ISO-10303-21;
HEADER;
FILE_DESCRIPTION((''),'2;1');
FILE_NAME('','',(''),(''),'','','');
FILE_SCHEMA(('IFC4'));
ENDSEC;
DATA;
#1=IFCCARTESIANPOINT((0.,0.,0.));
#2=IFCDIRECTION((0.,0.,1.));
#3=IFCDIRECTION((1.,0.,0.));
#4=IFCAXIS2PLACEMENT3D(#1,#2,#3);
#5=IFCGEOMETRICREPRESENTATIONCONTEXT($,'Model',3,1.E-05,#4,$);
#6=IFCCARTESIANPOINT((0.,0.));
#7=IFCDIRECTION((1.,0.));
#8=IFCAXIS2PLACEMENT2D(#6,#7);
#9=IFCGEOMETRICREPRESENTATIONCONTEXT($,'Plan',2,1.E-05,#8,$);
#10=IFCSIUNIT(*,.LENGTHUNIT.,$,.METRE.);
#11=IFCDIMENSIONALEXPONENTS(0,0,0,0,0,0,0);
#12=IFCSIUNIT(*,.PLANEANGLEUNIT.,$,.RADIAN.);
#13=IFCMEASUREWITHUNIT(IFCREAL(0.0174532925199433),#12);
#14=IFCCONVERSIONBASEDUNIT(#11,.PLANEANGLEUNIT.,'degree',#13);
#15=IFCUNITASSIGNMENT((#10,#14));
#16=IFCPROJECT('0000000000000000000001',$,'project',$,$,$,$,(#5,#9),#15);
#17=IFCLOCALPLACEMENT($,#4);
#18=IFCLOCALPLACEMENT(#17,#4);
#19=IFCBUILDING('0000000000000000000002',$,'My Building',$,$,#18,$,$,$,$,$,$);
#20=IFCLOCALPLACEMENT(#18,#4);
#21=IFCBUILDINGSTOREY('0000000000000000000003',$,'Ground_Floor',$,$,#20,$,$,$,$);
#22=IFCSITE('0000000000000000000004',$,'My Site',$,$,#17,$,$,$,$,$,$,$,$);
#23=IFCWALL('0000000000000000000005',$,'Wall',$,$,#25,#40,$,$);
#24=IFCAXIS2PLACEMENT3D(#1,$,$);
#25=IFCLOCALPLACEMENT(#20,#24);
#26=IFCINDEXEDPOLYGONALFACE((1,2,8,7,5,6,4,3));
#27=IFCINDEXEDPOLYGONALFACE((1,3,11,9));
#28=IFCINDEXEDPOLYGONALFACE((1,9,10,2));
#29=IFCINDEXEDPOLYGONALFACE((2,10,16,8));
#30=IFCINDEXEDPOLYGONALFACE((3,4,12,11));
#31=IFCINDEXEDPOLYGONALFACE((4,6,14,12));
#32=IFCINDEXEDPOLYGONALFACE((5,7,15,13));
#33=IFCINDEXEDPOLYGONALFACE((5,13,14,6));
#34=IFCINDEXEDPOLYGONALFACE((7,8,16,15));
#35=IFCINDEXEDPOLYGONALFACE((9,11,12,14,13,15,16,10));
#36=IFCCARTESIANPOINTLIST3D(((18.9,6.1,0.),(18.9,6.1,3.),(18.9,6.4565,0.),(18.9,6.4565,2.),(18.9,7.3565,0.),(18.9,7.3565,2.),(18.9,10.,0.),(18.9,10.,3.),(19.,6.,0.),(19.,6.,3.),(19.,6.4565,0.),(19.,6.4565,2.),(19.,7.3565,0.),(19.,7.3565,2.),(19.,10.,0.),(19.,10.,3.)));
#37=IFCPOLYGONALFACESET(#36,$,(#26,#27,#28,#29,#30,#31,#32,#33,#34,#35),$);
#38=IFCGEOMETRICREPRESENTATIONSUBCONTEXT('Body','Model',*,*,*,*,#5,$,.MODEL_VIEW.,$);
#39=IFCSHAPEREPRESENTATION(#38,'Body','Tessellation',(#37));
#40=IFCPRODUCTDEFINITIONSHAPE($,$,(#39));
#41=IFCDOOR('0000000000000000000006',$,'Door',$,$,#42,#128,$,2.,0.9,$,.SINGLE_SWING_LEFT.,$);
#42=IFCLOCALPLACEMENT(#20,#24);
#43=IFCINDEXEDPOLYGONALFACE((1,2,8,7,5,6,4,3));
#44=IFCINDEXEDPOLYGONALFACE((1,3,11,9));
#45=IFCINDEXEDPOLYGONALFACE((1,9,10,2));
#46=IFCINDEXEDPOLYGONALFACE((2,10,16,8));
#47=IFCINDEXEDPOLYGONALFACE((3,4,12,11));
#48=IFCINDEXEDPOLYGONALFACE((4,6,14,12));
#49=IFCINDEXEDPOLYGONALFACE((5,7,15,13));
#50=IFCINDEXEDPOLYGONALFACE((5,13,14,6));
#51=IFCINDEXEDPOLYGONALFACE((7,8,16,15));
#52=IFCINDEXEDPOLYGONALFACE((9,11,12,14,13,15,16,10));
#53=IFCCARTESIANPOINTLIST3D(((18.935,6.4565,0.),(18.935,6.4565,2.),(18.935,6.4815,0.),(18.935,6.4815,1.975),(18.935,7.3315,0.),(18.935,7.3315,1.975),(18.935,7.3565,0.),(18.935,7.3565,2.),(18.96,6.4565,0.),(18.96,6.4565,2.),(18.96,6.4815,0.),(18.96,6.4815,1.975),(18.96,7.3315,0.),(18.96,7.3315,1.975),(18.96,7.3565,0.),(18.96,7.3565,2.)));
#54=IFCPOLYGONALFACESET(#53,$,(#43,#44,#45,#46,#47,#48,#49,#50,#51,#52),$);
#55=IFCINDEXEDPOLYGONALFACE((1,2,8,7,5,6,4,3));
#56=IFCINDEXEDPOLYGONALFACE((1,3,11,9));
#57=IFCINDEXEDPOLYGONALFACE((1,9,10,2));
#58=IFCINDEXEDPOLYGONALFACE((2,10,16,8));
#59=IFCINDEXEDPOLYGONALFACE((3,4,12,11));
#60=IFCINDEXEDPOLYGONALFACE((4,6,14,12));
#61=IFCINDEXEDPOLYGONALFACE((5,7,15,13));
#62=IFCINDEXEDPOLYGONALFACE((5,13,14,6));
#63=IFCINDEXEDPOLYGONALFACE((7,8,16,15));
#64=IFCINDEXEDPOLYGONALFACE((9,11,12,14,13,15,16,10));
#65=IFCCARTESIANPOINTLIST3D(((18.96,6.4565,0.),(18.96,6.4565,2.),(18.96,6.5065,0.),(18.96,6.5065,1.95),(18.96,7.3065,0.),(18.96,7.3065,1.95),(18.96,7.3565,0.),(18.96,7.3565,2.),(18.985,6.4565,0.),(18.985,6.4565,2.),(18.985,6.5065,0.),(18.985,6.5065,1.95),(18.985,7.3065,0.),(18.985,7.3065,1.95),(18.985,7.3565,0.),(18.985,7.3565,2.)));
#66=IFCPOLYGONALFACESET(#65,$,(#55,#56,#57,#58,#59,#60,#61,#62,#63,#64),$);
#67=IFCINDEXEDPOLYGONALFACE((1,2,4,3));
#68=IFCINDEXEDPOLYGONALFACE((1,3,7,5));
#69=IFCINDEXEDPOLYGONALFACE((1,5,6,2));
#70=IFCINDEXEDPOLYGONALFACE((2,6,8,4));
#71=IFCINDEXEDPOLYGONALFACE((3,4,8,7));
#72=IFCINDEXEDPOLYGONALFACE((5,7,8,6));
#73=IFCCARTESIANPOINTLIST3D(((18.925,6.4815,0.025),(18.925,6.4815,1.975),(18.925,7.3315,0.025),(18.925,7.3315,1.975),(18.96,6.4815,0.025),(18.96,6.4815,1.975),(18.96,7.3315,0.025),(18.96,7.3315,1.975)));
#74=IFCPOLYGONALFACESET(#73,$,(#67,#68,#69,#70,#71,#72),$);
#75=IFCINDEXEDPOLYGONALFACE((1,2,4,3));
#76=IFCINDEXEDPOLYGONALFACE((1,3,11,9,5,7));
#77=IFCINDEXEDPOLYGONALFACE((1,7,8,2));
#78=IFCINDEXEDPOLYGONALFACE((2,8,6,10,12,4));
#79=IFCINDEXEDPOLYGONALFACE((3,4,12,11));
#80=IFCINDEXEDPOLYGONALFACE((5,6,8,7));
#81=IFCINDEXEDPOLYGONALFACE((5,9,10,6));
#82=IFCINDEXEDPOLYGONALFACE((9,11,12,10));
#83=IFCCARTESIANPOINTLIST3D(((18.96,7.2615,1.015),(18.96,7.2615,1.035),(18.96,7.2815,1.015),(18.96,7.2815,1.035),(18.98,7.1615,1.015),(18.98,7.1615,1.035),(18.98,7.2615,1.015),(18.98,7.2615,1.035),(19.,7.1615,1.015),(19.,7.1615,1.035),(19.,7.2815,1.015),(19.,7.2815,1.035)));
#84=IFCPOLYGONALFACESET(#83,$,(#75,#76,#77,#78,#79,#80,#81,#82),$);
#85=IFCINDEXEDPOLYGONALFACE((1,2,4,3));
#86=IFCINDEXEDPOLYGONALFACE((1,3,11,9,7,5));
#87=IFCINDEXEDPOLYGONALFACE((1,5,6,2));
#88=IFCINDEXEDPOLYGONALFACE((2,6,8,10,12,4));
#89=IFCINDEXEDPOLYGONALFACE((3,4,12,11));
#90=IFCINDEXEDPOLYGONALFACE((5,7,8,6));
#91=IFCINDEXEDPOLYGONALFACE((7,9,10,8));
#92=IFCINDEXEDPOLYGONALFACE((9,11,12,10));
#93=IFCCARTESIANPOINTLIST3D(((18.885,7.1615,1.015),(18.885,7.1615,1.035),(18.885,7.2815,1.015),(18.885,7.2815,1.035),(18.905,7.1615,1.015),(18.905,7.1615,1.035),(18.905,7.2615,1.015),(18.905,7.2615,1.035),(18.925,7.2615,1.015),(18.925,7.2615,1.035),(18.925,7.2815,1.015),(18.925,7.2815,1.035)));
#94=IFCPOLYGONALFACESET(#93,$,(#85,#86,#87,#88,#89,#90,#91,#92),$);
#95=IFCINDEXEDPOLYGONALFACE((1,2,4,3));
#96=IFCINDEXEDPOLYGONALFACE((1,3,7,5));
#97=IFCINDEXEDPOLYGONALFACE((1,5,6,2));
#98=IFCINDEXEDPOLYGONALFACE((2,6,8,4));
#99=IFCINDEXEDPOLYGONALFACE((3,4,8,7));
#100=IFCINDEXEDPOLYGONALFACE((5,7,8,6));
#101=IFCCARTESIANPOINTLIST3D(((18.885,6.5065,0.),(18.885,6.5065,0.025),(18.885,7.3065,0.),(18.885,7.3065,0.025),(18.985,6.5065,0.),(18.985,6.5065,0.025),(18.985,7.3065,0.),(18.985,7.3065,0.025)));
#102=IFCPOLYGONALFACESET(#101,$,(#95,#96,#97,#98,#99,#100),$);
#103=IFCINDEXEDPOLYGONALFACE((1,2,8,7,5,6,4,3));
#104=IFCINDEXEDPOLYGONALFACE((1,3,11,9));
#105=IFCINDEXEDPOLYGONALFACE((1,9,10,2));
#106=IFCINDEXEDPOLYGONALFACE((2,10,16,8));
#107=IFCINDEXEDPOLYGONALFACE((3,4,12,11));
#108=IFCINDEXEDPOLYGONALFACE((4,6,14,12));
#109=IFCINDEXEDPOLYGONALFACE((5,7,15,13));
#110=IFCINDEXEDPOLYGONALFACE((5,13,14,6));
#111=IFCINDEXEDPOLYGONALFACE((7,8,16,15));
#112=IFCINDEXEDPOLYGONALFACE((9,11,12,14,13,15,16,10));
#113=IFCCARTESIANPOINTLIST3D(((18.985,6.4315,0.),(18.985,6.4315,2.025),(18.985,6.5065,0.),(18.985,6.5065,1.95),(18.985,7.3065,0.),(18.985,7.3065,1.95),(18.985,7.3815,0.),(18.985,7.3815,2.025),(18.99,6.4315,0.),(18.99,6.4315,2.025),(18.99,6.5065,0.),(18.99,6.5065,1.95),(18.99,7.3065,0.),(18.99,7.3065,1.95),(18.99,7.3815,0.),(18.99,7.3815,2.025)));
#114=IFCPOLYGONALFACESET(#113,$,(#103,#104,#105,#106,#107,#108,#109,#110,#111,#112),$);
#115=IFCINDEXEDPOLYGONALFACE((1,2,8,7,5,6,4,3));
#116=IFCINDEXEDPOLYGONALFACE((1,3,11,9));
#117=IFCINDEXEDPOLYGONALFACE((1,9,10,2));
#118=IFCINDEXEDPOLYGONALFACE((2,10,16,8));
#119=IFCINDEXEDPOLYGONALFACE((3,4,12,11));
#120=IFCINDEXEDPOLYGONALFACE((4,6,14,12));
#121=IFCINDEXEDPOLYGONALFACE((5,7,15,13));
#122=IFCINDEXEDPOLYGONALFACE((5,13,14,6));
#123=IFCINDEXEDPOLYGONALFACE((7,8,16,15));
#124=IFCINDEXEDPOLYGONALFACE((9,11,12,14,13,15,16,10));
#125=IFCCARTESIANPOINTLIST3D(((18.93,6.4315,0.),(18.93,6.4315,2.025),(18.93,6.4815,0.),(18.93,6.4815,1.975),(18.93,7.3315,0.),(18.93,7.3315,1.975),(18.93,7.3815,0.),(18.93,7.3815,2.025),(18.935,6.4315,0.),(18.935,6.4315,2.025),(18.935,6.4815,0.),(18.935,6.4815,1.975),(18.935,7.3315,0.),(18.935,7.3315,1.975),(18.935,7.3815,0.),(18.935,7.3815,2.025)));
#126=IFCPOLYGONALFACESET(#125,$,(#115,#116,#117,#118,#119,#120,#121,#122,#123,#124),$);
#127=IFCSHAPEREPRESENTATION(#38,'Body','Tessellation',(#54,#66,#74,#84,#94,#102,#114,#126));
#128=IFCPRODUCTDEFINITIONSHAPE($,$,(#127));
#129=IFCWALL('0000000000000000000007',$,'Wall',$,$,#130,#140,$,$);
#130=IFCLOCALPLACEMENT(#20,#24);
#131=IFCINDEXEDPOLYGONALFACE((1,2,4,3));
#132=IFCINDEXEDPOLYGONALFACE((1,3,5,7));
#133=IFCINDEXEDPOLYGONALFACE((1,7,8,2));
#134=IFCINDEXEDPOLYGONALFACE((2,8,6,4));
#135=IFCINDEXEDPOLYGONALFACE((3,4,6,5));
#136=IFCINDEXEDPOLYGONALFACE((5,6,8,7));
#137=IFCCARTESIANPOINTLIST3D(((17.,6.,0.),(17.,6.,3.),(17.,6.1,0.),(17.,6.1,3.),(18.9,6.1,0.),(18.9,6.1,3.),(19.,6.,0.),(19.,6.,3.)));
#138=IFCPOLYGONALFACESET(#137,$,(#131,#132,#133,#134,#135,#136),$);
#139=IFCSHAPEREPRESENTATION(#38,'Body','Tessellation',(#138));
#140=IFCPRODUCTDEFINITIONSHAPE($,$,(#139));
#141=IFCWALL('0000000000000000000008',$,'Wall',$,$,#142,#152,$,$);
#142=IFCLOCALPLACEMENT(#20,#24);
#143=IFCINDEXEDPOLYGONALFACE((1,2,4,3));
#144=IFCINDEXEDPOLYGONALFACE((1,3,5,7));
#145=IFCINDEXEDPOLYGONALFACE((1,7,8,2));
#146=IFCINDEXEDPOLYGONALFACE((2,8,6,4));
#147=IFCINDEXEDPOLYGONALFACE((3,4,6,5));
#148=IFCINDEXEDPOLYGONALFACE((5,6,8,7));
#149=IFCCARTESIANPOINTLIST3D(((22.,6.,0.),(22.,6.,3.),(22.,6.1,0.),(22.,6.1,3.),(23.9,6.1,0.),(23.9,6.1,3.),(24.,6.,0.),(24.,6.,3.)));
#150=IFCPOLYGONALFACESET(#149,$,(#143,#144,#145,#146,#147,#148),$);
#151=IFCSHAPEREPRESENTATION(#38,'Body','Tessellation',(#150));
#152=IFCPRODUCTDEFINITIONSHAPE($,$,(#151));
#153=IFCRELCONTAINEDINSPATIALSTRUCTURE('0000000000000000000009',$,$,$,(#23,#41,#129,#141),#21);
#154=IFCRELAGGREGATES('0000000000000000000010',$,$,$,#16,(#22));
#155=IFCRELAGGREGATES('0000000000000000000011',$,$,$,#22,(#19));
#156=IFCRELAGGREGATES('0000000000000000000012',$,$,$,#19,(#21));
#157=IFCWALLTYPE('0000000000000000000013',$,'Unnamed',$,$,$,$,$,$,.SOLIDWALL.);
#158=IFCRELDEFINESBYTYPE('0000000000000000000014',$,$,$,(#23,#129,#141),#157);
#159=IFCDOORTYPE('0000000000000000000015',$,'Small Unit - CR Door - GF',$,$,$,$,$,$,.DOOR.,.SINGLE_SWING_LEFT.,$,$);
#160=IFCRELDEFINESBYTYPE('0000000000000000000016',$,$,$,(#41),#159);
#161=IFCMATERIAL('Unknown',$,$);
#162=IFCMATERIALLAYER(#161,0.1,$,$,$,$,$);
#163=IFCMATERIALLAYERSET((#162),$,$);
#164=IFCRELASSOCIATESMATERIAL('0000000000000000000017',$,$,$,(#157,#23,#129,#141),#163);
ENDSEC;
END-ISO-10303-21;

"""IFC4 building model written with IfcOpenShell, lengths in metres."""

from ifc_helpers import new_model, entity, si_unit, converted_unit, frame, origin_with_axes, origin_2d_with_axis, place, context, subcontext, project, spatial, line, indexed_curve, outline, extrude, shape, source, transform, mapped, material, layer, layer_set, layer_usage, type_object, type_shapes, element, fill, save


model = new_model("IFC4")

# Units and contexts
model_context = context("Model", 3, precision=1e-05, world=origin_with_axes())
plan_context = context("Plan", 2, precision=1e-05, world=origin_2d_with_axis())
body_context_1 = subcontext(model_context, "Body", "Model", "MODEL_VIEW")
body_context_2 = subcontext(plan_context, "Body", "Plan", "PLAN_VIEW")
ifc_project = project(units=[si_unit("LENGTHUNIT", "METRE"), converted_unit("PLANEANGLEUNIT", "degree", entity("IfcReal", 0.0174532925199433), si_unit("PLANEANGLEUNIT", "RADIAN"), dimensions=[0, 0, 0, 0, 0, 0, 0])], contexts=[model_context, plan_context])

# Site, building, storey
site_placement = place(None, origin_with_axes())
site = spatial("IfcSite", under=ifc_project, at=site_placement, Name="My Site")
building_placement = place(site_placement, origin_with_axes())
building = spatial("IfcBuilding", under=site, at=building_placement, Name="My Building")
storey_placement = place(building_placement, origin_with_axes())
storey = spatial("IfcBuildingStorey", under=building, at=storey_placement, Name="Ground_Floor")

# Shared definitions
ifc_material = material(Name="Unknown")
ifc_layer = layer(ifc_material, 0.1)
ifc_layer_set = layer_set([ifc_layer])
wall_type = type_object("IfcWallType", Name="Unnamed", PredefinedType="SOLIDWALL", material=ifc_layer_set)

# Wall, opening, door
ifc_layer_usage_1 = layer_usage(ifc_layer_set, "AXIS2", "POSITIVE", 0.0)
wall_1_placement = place(storey_placement, frame((19.0, 6.0, 0.0), z_axis=(0.0, 0.0, 1.0), x_axis=(0.0, 1.0, 0.0)))
wall_1 = element("IfcWall", 1, at=wall_1_placement, inside=storey, type_object=wall_type, material=ifc_layer_usage_1, Name="Wall", context=body_context_1, shape_type="SweptSolid", body=[
    extrude(outline(indexed_curve([(0.0, 0.0), (0.1, 0.1), (4.0, 0.1), (4.0, 0.0)], segments=[line(1, 2, 3, 4, 1)])), origin_with_axes(), (0.0, 0.0, 1.0), 3.0),
])
shared_shape_1 = source(origin_with_axes(), body_context_1, "Body", "SweptSolid", [
    extrude(outline(indexed_curve([(0.0, 0.0), (0.9, 0.0), (0.9, 2.0), (0.0, 2.0)], segments=[line(1, 2, 3, 4, 1)])), frame((0.0, -0.6, 0.0), z_axis=(0.0, -1.0, 0.0), x_axis=(1.0, 0.0, 0.0)), (0.0, 0.0, -1.0), 1.2),
])
opening_1_placement = place(wall_1_placement, frame((0.4565, 0.015, 0.0), z_axis=(0.0, 0.0, 1.0), x_axis=(1.0, 0.0, 0.0)))
opening_1 = element("IfcOpeningElement", 2, at=opening_1_placement, cuts=wall_1, PredefinedType="OPENING", context=body_context_1, shape_type="MappedRepresentation", body=[
    mapped(shared_shape_1, transform((0.0, 0.0, 0.0), x_axis=(1.0, 0.0, 0.0), y_axis=(0.0, 1.0, 0.0), z_axis=(0.0, 0.0, 1.0), scale=1.0)),
])
door_type_1 = type_object("IfcDoorType", Name="Small Unit - CR Door - GF", OperationType="SINGLE_SWING_LEFT", PredefinedType="DOOR")
shared_shape_2 = source(origin_with_axes(), body_context_1, "Body", "SweptSolid", [
    extrude(outline(indexed_curve([(0.0, 0.0), (0.0, 2.0), (0.9, 2.0), (0.9, 0.0), (0.875, 0.0), (0.875, 1.975), (0.025, 1.975), (0.025, 0.0)], segments=[line(1, 2, 3, 4, 5, 6, 7, 8, 1)])), frame((0.0, 0.025, 0.0), z_axis=(0.0, -1.0, 0.0), x_axis=(1.0, 0.0, 0.0)), (0.0, 0.0, -1.0), 0.025),
    extrude(outline(indexed_curve([(0.0, 0.0), (0.0, 2.0), (0.9, 2.0), (0.9, 0.0), (0.85, 0.0), (0.85, 1.95), (0.05, 1.95), (0.05, 0.0)], segments=[line(1, 2, 3, 4, 5, 6, 7, 8, 1)])), frame((0.0, 0.0, 0.0), z_axis=(0.0, -1.0, 0.0), x_axis=(1.0, 0.0, 0.0)), (0.0, 0.0, -1.0), 0.025),
    extrude(outline(indexed_curve([(0.0, 0.0), (0.85, 0.0), (0.85, 0.035), (0.0, 0.035)], segments=[line(1, 2, 3, 4, 1)])), frame((0.025, 0.025, 0.025), z_axis=(0.0, 0.0, 1.0), x_axis=(1.0, 0.0, 0.0)), (0.0, 0.0, 1.0), 1.95),
    extrude(outline(indexed_curve([(0.0, 0.0), (0.0, -0.04), (-0.12, -0.04), (-0.12, -0.02), (-0.02, -0.02), (-0.02, 0.0)], segments=[line(1, 2, 3, 4, 5, 6, 1)])), frame((0.825, 0.025, 1.015), z_axis=(0.0, 0.0, 1.0), x_axis=(1.0, 0.0, 0.0)), (0.0, 0.0, 1.0), 0.02),
    extrude(outline(indexed_curve([(0.0, 0.0), (0.0, 0.04), (-0.12, 0.04), (-0.12, 0.02), (-0.02, 0.02), (-0.02, 0.0)], segments=[line(1, 2, 3, 4, 5, 6, 1)])), frame((0.825, 0.06, 1.015), z_axis=(0.0, 0.0, 1.0), x_axis=(1.0, 0.0, 0.0)), (0.0, 0.0, 1.0), 0.02),
    extrude(outline(indexed_curve([(0.0, 0.0), (0.8, 0.0), (0.8, 0.1), (0.0, 0.1)], segments=[line(1, 2, 3, 4, 1)])), frame((0.05, 0.0, 0.0), z_axis=(0.0, 0.0, 1.0), x_axis=(1.0, 0.0, 0.0)), (0.0, 0.0, 1.0), 0.025),
    extrude(outline(indexed_curve([(0.0, 0.0), (0.0, 2.025), (0.95, 2.025), (0.95, 0.0), (0.875, 0.0), (0.875, 1.95), (0.075, 1.95), (0.075, 0.0)], segments=[line(1, 2, 3, 4, 5, 6, 7, 8, 1)])), frame((-0.025, -0.005, 0.0), z_axis=(0.0, -1.0, 0.0), x_axis=(1.0, 0.0, 0.0)), (0.0, 0.0, -1.0), 0.005),
    extrude(outline(indexed_curve([(0.0, 0.0), (0.0, 2.025), (0.95, 2.025), (0.95, 0.0), (0.9, 0.0), (0.9, 1.975), (0.05, 1.975), (0.05, 0.0)], segments=[line(1, 2, 3, 4, 5, 6, 7, 8, 1)])), frame((-0.025, 0.05, 0.0), z_axis=(0.0, -1.0, 0.0), x_axis=(1.0, 0.0, 0.0)), (0.0, 0.0, -1.0), 0.005),
])
shared_shape_3 = source(origin_with_axes(), body_context_2, "Body", "Curve2D", [
    entity("IfcIndexedPolyCurve", entity("IfcCartesianPointList2D", [[0.0, 0.0], [0.0, 0.05], [0.025, 0.05], [0.025, 0.025], [0.05, 0.025], [0.05, 0.0]]), [entity("IfcLineIndex", [1, 2, 3, 4, 5, 6, 1])]),
    entity("IfcIndexedPolyCurve", entity("IfcCartesianPointList2D", [[0.9, 0.0], [0.9, 0.05], [0.875, 0.05], [0.875, 0.025], [0.85, 0.025], [0.85, 0.0]]), [entity("IfcLineIndex", [1, 2, 3, 4, 5, 6, 1])]),
    entity("IfcTrimmedCurve", entity("IfcEllipse", entity("IfcAxis2Placement2D", entity("IfcCartesianPoint", [0.06, 0.05]), entity("IfcDirection", [1.0, 0.0])), 0.815, 0.85), [entity("IfcCartesianPoint", [0.875, 0.05])], [entity("IfcCartesianPoint", [0.06, 0.9])], True, "CARTESIAN"),
    entity("IfcIndexedPolyCurve", entity("IfcCartesianPointList2D", [[0.025, 0.05], [0.06, 0.05], [0.06, 0.9], [0.025, 0.9]]), [entity("IfcLineIndex", [1, 2, 3, 4, 1])]),
])
type_shapes(door_type_1, [shared_shape_2, shared_shape_3])
door_1_placement = place(opening_1_placement, origin_with_axes())
door_1 = element("IfcDoor", 3, at=door_1_placement, inside=storey, type_object=door_type_1, Name="Door", OperationType="SINGLE_SWING_LEFT", OverallHeight=2.0, OverallWidth=0.9, shapes=[
    shape(body_context_1, "Body", "MappedRepresentation", [mapped(shared_shape_2, transform((0.0, 0.0, 0.0), x_axis=(1.0, 0.0, 0.0), y_axis=(0.0, 1.0, 0.0), z_axis=(0.0, 0.0, 1.0), scale=1.0))]),
    shape(body_context_2, "Body", "MappedRepresentation", [mapped(shared_shape_3, transform((0.0, 0.0, 0.0), x_axis=(1.0, 0.0, 0.0), y_axis=(0.0, 1.0, 0.0), z_axis=(0.0, 0.0, 1.0), scale=1.0))]),
])
fill(opening_1, door_1)

# Walls
ifc_layer_usage_2 = layer_usage(ifc_layer_set, "AXIS2", "POSITIVE", 0.0)
wall_2_placement = place(storey_placement, frame((17.0, 6.0, 0.0), z_axis=(0.0, 0.0, 1.0), x_axis=(1.0, 0.0, 0.0)))
element("IfcWall", 4, at=wall_2_placement, inside=storey, type_object=wall_type, material=ifc_layer_usage_2, Name="Wall", context=body_context_1, shape_type="SweptSolid", body=[
    extrude(outline(indexed_curve([(0.0, 0.0), (0.0, 0.1), (1.9, 0.1), (2.0, 0.0)], segments=[line(1, 2, 3, 4, 1)])), origin_with_axes(), (0.0, 0.0, 1.0), 3.0),
])
ifc_layer_usage_3 = layer_usage(ifc_layer_set, "AXIS2", "POSITIVE", 0.0)
wall_3_placement = place(storey_placement, frame((22.0, 6.0, 0.0), z_axis=(0.0, 0.0, 1.0), x_axis=(1.0, 0.0, 0.0)))
element("IfcWall", 5, at=wall_3_placement, inside=storey, type_object=wall_type, material=ifc_layer_usage_3, Name="Wall", context=body_context_1, shape_type="SweptSolid", body=[
    extrude(outline(indexed_curve([(0.0, 0.0), (0.0, 0.1), (1.9, 0.1), (2.0, 0.0)], segments=[line(1, 2, 3, 4, 1)])), origin_with_axes(), (0.0, 0.0, 1.0), 3.0),
])

save(model, "model.ifc")
